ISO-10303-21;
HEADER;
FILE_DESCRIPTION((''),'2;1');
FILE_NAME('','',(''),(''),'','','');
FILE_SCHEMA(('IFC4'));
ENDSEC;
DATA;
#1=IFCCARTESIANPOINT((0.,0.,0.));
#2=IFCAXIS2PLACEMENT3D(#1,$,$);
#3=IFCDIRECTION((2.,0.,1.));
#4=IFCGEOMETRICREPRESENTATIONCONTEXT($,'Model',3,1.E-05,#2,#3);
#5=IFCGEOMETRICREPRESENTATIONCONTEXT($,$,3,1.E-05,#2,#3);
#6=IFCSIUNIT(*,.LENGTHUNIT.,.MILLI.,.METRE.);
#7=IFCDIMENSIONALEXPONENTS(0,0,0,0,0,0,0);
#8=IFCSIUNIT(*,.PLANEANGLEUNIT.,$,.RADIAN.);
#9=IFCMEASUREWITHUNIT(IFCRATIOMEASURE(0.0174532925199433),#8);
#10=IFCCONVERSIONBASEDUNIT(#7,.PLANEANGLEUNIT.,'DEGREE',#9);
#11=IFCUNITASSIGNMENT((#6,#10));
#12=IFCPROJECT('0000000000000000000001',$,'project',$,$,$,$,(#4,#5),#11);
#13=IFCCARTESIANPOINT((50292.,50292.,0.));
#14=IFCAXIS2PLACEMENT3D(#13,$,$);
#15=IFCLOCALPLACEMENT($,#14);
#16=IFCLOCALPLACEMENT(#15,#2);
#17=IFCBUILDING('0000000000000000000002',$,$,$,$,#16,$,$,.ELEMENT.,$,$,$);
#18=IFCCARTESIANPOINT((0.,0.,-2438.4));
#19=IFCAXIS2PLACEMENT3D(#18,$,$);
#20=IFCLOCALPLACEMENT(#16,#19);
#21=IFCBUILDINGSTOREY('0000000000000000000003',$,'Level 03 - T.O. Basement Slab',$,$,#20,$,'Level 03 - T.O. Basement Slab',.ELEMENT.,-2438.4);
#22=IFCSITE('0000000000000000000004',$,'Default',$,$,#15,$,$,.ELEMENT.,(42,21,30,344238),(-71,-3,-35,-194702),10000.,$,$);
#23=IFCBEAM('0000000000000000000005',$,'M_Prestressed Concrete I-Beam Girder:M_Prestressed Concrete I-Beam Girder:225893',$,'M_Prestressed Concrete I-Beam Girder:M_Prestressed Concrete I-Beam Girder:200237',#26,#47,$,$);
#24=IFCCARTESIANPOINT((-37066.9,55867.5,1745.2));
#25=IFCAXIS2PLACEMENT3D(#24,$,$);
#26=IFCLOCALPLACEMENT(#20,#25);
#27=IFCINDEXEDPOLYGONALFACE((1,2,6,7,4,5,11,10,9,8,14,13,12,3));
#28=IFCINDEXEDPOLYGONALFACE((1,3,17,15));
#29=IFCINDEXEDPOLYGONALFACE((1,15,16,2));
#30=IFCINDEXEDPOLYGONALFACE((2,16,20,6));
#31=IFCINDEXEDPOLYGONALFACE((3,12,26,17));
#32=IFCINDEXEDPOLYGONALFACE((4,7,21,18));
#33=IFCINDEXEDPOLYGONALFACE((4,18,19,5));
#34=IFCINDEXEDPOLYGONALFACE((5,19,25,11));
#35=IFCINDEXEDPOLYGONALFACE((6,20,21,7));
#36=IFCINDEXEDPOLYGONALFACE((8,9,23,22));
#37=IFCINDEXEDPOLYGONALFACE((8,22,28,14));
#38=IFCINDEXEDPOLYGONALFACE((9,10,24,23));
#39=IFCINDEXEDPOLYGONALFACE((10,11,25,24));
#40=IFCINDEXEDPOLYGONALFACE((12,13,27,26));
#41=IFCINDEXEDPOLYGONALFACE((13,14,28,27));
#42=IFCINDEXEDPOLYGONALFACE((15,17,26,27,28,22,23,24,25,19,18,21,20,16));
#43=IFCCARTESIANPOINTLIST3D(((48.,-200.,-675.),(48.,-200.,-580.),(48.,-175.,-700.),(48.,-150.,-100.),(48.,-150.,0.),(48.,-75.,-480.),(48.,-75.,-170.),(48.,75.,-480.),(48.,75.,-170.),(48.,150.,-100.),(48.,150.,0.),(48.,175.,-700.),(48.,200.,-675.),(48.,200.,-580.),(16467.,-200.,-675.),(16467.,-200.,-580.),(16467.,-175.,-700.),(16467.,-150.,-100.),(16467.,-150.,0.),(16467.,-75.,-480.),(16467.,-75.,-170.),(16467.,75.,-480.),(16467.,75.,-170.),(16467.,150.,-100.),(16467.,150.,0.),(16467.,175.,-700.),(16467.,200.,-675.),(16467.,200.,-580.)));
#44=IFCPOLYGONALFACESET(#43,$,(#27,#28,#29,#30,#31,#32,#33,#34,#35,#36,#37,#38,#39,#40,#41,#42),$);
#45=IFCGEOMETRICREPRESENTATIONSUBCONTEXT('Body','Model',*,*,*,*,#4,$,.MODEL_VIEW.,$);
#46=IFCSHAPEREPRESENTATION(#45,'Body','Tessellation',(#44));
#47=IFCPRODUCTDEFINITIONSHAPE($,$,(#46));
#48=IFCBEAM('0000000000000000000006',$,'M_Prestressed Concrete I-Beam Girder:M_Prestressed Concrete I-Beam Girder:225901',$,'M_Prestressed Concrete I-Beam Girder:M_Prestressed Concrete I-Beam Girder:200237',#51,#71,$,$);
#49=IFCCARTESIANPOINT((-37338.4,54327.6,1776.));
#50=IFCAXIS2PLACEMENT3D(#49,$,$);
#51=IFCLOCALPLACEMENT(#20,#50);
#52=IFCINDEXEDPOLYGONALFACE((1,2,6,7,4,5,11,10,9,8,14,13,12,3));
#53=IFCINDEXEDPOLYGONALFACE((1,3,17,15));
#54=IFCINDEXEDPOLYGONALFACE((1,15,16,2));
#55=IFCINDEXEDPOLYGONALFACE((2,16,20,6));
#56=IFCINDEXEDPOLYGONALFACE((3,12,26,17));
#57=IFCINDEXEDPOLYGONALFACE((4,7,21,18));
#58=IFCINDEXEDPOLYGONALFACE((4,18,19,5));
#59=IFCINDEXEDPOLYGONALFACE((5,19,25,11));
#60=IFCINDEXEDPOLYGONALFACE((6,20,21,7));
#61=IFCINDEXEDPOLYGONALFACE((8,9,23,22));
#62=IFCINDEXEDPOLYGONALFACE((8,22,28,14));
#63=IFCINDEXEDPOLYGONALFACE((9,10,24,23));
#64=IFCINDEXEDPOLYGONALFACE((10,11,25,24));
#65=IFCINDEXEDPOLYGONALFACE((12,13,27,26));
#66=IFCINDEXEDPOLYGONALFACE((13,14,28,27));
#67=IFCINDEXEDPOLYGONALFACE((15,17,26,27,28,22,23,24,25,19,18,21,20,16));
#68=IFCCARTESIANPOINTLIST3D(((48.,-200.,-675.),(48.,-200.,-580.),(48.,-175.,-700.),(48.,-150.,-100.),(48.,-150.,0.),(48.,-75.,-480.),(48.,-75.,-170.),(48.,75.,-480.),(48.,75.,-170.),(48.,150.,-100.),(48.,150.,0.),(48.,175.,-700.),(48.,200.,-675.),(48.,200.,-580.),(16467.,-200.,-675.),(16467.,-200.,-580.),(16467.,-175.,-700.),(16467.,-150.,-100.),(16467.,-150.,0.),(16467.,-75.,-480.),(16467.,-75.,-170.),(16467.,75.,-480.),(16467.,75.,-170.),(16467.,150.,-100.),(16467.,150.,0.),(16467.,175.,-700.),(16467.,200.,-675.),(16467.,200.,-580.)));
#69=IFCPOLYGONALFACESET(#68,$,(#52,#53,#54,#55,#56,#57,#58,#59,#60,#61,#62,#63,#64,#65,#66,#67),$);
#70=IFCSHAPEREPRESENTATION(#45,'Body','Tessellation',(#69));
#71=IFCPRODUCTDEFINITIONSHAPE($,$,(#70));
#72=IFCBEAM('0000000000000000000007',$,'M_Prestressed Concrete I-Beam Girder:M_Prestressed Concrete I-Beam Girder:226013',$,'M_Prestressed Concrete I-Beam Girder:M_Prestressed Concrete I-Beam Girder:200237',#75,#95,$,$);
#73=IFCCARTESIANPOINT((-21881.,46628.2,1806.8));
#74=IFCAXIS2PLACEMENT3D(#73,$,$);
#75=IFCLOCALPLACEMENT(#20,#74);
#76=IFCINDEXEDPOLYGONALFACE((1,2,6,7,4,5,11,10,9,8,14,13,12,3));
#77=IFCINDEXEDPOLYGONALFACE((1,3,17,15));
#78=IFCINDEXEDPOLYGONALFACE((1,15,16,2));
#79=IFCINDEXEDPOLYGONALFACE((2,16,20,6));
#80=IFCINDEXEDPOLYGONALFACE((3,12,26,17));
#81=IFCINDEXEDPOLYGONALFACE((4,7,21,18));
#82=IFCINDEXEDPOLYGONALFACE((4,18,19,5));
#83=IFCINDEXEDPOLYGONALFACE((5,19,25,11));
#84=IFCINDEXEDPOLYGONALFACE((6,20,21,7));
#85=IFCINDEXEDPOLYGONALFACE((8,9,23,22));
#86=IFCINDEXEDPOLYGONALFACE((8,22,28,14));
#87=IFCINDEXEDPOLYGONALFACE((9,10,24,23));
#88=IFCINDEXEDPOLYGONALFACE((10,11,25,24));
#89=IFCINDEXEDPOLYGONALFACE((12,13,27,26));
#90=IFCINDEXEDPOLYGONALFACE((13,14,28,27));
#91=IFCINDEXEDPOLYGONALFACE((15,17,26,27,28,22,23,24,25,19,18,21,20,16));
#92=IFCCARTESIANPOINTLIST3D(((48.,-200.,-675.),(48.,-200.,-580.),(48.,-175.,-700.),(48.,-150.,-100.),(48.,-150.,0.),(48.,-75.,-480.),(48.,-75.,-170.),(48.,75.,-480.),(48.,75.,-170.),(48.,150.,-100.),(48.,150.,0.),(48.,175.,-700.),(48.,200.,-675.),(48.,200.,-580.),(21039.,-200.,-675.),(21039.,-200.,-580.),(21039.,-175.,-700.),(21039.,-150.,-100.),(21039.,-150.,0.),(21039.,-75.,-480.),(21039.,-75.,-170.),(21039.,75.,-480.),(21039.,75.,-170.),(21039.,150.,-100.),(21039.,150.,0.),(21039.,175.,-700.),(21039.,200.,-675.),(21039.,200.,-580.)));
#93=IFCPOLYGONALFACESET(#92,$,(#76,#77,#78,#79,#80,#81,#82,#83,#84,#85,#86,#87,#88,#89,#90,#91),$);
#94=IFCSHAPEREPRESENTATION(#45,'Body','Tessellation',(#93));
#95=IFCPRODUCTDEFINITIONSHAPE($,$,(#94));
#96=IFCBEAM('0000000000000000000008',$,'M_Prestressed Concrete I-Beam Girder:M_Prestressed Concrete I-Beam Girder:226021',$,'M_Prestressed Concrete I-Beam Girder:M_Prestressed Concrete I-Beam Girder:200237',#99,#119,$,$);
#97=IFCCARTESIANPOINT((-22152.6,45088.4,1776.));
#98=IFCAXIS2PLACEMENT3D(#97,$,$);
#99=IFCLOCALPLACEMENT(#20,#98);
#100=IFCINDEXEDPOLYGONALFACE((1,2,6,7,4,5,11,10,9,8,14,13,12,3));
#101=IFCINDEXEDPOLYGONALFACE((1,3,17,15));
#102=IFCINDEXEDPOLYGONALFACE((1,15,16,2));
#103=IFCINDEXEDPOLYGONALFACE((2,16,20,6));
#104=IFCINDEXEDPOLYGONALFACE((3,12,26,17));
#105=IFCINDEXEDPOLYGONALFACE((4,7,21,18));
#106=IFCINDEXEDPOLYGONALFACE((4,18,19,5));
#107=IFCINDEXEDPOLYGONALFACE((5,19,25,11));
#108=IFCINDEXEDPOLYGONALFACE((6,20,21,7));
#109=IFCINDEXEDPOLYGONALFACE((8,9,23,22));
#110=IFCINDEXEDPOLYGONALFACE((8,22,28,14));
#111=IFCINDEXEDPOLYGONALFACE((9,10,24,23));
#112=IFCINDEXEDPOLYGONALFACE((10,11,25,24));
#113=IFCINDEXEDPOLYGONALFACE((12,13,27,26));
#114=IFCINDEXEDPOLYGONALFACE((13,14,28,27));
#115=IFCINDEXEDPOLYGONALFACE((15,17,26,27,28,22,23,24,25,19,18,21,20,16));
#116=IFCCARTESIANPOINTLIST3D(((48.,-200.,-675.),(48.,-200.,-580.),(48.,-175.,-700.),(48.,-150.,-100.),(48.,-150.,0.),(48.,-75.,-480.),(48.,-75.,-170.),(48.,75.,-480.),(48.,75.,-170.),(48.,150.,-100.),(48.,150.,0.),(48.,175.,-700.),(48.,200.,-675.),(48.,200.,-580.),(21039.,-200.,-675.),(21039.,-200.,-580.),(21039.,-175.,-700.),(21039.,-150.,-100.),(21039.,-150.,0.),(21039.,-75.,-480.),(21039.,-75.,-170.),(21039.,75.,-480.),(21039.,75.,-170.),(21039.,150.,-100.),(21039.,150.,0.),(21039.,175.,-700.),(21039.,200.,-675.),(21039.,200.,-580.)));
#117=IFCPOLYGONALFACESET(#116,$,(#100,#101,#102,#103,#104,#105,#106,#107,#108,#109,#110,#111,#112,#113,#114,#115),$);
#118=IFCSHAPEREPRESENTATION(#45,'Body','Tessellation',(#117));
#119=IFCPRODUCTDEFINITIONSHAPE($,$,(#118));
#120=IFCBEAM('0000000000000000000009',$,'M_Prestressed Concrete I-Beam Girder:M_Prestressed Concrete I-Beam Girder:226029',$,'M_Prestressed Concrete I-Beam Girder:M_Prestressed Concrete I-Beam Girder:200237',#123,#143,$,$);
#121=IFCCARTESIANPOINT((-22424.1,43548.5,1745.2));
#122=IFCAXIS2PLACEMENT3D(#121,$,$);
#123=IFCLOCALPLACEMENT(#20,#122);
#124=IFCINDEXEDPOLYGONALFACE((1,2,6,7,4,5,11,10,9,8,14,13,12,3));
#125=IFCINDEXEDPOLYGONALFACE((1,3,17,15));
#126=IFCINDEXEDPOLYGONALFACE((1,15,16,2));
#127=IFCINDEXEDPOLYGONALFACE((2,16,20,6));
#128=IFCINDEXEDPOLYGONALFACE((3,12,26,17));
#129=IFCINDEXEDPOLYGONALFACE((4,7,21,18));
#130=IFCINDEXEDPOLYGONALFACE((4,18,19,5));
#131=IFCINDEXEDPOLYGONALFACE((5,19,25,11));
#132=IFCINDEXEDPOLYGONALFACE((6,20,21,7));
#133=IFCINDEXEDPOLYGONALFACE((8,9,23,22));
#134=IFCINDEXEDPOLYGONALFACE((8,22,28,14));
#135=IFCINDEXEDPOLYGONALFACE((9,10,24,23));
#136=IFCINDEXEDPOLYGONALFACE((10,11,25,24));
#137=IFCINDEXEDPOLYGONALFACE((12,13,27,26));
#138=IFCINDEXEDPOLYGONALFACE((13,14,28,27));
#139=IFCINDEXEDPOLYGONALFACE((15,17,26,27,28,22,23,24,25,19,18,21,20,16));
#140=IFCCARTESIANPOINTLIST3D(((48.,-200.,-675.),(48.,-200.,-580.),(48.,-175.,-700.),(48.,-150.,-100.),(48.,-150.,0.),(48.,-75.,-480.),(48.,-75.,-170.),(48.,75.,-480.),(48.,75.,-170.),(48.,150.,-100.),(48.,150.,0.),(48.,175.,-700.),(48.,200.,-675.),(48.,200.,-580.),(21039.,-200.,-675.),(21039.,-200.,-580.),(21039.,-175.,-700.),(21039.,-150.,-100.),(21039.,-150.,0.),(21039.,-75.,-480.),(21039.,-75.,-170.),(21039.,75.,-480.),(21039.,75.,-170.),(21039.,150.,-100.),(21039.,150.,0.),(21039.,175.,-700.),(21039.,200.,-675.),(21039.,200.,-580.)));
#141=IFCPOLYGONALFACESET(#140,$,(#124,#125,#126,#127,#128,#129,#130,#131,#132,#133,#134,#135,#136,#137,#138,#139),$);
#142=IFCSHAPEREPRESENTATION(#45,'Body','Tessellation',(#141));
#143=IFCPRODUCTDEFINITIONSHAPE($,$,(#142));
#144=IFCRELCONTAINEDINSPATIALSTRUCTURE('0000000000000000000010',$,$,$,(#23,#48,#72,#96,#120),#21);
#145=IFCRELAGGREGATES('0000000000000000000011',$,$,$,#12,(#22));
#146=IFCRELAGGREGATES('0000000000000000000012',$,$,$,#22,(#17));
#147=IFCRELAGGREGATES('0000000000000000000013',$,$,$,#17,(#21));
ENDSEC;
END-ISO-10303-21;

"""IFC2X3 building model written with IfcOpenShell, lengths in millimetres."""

from ifc_helpers import new_model, entity, si_unit, converted_unit, direction, frame, origin, place, context, subcontext, project, spatial, polyline, outline, extrude, element, save


model = new_model("IFC2X3")

# Units and contexts
model_context = context("Model", 3, precision=1e-05, world=origin(), true_north=direction((2.0, 0.0, 1.0)))
context_of_model = context(None, 3, precision=1e-05, world=origin(), true_north=direction((2.0, 0.0, 1.0)))
body_context = subcontext(model_context, "Body", "Model", "MODEL_VIEW")
ifc_project = project(units=[si_unit("LENGTHUNIT", "METRE", prefix="MILLI"), converted_unit("PLANEANGLEUNIT", "DEGREE", entity("IfcRatioMeasure", 0.0174532925199433), si_unit("PLANEANGLEUNIT", "RADIAN"), dimensions=[0, 0, 0, 0, 0, 0, 0])], contexts=[model_context, context_of_model])

# Site, building, storey
site_placement = place(None, frame((50292.0, 50292.0, 0.0)))
site = spatial("IfcSite", under=ifc_project, at=site_placement, Name="Default", CompositionType="ELEMENT", RefLatitude=(42, 21, 30, 344238), RefLongitude=(-71, -3, -35, -194702), RefElevation=10000.0)
building_placement = place(site_placement, origin())
building = spatial("IfcBuilding", under=site, at=building_placement, CompositionType="ELEMENT")
storey_placement = place(building_placement, frame((0.0, 0.0, -2438.4)))
storey = spatial("IfcBuildingStorey", under=building, at=storey_placement, Name="Level 03 - T.O. Basement Slab", LongName="Level 03 - T.O. Basement Slab", CompositionType="ELEMENT", Elevation=-2438.4)

# Beams
beam_1_placement = place(storey_placement, frame((-37066.9, 55867.5, 1745.2)))
element("IfcBeam", 1, at=beam_1_placement, inside=storey, Name="M_Prestressed Concrete I-Beam Girder:M_Prestressed Concrete I-Beam Girder:225893", ObjectType="M_Prestressed Concrete I-Beam Girder:M_Prestressed Concrete I-Beam Girder:200237", context=body_context, shape_type="SweptSolid", body=[
    extrude(outline(polyline([(193.6, -200.0), (288.6, -200.0), (313.6, -175.0), (313.6, 175.0), (288.6, 200.0), (193.6, 200.0), (93.6, 75.0), (-216.4, 75.0), (-286.4, 150.0), (-386.4, 150.0), (-386.4, -150.0), (-286.4, -150.0), (-216.4, -75.0), (93.6, -75.0), (193.6, -200.0)])), frame((48.0, 0.0, -386.4), z_axis=(1.0, 0.0, 0.0), x_axis=(0.0, 0.0, -1.0)), (0.0, 0.0, 1.0), 16419.0),
])
beam_2_placement = place(storey_placement, frame((-37338.4, 54327.6, 1776.0)))
element("IfcBeam", 2, at=beam_2_placement, inside=storey, Name="M_Prestressed Concrete I-Beam Girder:M_Prestressed Concrete I-Beam Girder:225901", ObjectType="M_Prestressed Concrete I-Beam Girder:M_Prestressed Concrete I-Beam Girder:200237", context=body_context, shape_type="SweptSolid", body=[
    extrude(outline(polyline([(193.6, -200.0), (288.6, -200.0), (313.6, -175.0), (313.6, 175.0), (288.6, 200.0), (193.6, 200.0), (93.6, 75.0), (-216.4, 75.0), (-286.4, 150.0), (-386.4, 150.0), (-386.4, -150.0), (-286.4, -150.0), (-216.4, -75.0), (93.6, -75.0), (193.6, -200.0)])), frame((48.0, 0.0, -386.4), z_axis=(1.0, 0.0, 0.0), x_axis=(0.0, 0.0, -1.0)), (0.0, 0.0, 1.0), 16419.0),
])
beam_3_placement = place(storey_placement, frame((-21881.0, 46628.2, 1806.8)))
element("IfcBeam", 3, at=beam_3_placement, inside=storey, Name="M_Prestressed Concrete I-Beam Girder:M_Prestressed Concrete I-Beam Girder:226013", ObjectType="M_Prestressed Concrete I-Beam Girder:M_Prestressed Concrete I-Beam Girder:200237", context=body_context, shape_type="SweptSolid", body=[
    extrude(outline(polyline([(193.6, -200.0), (288.6, -200.0), (313.6, -175.0), (313.6, 175.0), (288.6, 200.0), (193.6, 200.0), (93.6, 75.0), (-216.4, 75.0), (-286.4, 150.0), (-386.4, 150.0), (-386.4, -150.0), (-286.4, -150.0), (-216.4, -75.0), (93.6, -75.0), (193.6, -200.0)])), frame((48.0, 0.0, -386.4), z_axis=(1.0, 0.0, 0.0), x_axis=(0.0, 0.0, -1.0)), (0.0, 0.0, 1.0), 20991.0),
])
beam_4_placement = place(storey_placement, frame((-22152.6, 45088.4, 1776.0)))
element("IfcBeam", 4, at=beam_4_placement, inside=storey, Name="M_Prestressed Concrete I-Beam Girder:M_Prestressed Concrete I-Beam Girder:226021", ObjectType="M_Prestressed Concrete I-Beam Girder:M_Prestressed Concrete I-Beam Girder:200237", context=body_context, shape_type="SweptSolid", body=[
    extrude(outline(polyline([(193.6, -200.0), (288.6, -200.0), (313.6, -175.0), (313.6, 175.0), (288.6, 200.0), (193.6, 200.0), (93.6, 75.0), (-216.4, 75.0), (-286.4, 150.0), (-386.4, 150.0), (-386.4, -150.0), (-286.4, -150.0), (-216.4, -75.0), (93.6, -75.0), (193.6, -200.0)])), frame((48.0, 0.0, -386.4), z_axis=(1.0, 0.0, 0.0), x_axis=(0.0, 0.0, -1.0)), (0.0, 0.0, 1.0), 20991.0),
])
beam_5_placement = place(storey_placement, frame((-22424.1, 43548.5, 1745.2)))
element("IfcBeam", 5, at=beam_5_placement, inside=storey, Name="M_Prestressed Concrete I-Beam Girder:M_Prestressed Concrete I-Beam Girder:226029", ObjectType="M_Prestressed Concrete I-Beam Girder:M_Prestressed Concrete I-Beam Girder:200237", context=body_context, shape_type="SweptSolid", body=[
    extrude(outline(polyline([(193.6, -200.0), (288.6, -200.0), (313.6, -175.0), (313.6, 175.0), (288.6, 200.0), (193.6, 200.0), (93.6, 75.0), (-216.4, 75.0), (-286.4, 150.0), (-386.4, 150.0), (-386.4, -150.0), (-286.4, -150.0), (-216.4, -75.0), (93.6, -75.0), (193.6, -200.0)])), frame((48.0, 0.0, -386.4), z_axis=(1.0, 0.0, 0.0), x_axis=(0.0, 0.0, -1.0)), (0.0, 0.0, 1.0), 20991.0),
])

save(model, "model.ifc")
